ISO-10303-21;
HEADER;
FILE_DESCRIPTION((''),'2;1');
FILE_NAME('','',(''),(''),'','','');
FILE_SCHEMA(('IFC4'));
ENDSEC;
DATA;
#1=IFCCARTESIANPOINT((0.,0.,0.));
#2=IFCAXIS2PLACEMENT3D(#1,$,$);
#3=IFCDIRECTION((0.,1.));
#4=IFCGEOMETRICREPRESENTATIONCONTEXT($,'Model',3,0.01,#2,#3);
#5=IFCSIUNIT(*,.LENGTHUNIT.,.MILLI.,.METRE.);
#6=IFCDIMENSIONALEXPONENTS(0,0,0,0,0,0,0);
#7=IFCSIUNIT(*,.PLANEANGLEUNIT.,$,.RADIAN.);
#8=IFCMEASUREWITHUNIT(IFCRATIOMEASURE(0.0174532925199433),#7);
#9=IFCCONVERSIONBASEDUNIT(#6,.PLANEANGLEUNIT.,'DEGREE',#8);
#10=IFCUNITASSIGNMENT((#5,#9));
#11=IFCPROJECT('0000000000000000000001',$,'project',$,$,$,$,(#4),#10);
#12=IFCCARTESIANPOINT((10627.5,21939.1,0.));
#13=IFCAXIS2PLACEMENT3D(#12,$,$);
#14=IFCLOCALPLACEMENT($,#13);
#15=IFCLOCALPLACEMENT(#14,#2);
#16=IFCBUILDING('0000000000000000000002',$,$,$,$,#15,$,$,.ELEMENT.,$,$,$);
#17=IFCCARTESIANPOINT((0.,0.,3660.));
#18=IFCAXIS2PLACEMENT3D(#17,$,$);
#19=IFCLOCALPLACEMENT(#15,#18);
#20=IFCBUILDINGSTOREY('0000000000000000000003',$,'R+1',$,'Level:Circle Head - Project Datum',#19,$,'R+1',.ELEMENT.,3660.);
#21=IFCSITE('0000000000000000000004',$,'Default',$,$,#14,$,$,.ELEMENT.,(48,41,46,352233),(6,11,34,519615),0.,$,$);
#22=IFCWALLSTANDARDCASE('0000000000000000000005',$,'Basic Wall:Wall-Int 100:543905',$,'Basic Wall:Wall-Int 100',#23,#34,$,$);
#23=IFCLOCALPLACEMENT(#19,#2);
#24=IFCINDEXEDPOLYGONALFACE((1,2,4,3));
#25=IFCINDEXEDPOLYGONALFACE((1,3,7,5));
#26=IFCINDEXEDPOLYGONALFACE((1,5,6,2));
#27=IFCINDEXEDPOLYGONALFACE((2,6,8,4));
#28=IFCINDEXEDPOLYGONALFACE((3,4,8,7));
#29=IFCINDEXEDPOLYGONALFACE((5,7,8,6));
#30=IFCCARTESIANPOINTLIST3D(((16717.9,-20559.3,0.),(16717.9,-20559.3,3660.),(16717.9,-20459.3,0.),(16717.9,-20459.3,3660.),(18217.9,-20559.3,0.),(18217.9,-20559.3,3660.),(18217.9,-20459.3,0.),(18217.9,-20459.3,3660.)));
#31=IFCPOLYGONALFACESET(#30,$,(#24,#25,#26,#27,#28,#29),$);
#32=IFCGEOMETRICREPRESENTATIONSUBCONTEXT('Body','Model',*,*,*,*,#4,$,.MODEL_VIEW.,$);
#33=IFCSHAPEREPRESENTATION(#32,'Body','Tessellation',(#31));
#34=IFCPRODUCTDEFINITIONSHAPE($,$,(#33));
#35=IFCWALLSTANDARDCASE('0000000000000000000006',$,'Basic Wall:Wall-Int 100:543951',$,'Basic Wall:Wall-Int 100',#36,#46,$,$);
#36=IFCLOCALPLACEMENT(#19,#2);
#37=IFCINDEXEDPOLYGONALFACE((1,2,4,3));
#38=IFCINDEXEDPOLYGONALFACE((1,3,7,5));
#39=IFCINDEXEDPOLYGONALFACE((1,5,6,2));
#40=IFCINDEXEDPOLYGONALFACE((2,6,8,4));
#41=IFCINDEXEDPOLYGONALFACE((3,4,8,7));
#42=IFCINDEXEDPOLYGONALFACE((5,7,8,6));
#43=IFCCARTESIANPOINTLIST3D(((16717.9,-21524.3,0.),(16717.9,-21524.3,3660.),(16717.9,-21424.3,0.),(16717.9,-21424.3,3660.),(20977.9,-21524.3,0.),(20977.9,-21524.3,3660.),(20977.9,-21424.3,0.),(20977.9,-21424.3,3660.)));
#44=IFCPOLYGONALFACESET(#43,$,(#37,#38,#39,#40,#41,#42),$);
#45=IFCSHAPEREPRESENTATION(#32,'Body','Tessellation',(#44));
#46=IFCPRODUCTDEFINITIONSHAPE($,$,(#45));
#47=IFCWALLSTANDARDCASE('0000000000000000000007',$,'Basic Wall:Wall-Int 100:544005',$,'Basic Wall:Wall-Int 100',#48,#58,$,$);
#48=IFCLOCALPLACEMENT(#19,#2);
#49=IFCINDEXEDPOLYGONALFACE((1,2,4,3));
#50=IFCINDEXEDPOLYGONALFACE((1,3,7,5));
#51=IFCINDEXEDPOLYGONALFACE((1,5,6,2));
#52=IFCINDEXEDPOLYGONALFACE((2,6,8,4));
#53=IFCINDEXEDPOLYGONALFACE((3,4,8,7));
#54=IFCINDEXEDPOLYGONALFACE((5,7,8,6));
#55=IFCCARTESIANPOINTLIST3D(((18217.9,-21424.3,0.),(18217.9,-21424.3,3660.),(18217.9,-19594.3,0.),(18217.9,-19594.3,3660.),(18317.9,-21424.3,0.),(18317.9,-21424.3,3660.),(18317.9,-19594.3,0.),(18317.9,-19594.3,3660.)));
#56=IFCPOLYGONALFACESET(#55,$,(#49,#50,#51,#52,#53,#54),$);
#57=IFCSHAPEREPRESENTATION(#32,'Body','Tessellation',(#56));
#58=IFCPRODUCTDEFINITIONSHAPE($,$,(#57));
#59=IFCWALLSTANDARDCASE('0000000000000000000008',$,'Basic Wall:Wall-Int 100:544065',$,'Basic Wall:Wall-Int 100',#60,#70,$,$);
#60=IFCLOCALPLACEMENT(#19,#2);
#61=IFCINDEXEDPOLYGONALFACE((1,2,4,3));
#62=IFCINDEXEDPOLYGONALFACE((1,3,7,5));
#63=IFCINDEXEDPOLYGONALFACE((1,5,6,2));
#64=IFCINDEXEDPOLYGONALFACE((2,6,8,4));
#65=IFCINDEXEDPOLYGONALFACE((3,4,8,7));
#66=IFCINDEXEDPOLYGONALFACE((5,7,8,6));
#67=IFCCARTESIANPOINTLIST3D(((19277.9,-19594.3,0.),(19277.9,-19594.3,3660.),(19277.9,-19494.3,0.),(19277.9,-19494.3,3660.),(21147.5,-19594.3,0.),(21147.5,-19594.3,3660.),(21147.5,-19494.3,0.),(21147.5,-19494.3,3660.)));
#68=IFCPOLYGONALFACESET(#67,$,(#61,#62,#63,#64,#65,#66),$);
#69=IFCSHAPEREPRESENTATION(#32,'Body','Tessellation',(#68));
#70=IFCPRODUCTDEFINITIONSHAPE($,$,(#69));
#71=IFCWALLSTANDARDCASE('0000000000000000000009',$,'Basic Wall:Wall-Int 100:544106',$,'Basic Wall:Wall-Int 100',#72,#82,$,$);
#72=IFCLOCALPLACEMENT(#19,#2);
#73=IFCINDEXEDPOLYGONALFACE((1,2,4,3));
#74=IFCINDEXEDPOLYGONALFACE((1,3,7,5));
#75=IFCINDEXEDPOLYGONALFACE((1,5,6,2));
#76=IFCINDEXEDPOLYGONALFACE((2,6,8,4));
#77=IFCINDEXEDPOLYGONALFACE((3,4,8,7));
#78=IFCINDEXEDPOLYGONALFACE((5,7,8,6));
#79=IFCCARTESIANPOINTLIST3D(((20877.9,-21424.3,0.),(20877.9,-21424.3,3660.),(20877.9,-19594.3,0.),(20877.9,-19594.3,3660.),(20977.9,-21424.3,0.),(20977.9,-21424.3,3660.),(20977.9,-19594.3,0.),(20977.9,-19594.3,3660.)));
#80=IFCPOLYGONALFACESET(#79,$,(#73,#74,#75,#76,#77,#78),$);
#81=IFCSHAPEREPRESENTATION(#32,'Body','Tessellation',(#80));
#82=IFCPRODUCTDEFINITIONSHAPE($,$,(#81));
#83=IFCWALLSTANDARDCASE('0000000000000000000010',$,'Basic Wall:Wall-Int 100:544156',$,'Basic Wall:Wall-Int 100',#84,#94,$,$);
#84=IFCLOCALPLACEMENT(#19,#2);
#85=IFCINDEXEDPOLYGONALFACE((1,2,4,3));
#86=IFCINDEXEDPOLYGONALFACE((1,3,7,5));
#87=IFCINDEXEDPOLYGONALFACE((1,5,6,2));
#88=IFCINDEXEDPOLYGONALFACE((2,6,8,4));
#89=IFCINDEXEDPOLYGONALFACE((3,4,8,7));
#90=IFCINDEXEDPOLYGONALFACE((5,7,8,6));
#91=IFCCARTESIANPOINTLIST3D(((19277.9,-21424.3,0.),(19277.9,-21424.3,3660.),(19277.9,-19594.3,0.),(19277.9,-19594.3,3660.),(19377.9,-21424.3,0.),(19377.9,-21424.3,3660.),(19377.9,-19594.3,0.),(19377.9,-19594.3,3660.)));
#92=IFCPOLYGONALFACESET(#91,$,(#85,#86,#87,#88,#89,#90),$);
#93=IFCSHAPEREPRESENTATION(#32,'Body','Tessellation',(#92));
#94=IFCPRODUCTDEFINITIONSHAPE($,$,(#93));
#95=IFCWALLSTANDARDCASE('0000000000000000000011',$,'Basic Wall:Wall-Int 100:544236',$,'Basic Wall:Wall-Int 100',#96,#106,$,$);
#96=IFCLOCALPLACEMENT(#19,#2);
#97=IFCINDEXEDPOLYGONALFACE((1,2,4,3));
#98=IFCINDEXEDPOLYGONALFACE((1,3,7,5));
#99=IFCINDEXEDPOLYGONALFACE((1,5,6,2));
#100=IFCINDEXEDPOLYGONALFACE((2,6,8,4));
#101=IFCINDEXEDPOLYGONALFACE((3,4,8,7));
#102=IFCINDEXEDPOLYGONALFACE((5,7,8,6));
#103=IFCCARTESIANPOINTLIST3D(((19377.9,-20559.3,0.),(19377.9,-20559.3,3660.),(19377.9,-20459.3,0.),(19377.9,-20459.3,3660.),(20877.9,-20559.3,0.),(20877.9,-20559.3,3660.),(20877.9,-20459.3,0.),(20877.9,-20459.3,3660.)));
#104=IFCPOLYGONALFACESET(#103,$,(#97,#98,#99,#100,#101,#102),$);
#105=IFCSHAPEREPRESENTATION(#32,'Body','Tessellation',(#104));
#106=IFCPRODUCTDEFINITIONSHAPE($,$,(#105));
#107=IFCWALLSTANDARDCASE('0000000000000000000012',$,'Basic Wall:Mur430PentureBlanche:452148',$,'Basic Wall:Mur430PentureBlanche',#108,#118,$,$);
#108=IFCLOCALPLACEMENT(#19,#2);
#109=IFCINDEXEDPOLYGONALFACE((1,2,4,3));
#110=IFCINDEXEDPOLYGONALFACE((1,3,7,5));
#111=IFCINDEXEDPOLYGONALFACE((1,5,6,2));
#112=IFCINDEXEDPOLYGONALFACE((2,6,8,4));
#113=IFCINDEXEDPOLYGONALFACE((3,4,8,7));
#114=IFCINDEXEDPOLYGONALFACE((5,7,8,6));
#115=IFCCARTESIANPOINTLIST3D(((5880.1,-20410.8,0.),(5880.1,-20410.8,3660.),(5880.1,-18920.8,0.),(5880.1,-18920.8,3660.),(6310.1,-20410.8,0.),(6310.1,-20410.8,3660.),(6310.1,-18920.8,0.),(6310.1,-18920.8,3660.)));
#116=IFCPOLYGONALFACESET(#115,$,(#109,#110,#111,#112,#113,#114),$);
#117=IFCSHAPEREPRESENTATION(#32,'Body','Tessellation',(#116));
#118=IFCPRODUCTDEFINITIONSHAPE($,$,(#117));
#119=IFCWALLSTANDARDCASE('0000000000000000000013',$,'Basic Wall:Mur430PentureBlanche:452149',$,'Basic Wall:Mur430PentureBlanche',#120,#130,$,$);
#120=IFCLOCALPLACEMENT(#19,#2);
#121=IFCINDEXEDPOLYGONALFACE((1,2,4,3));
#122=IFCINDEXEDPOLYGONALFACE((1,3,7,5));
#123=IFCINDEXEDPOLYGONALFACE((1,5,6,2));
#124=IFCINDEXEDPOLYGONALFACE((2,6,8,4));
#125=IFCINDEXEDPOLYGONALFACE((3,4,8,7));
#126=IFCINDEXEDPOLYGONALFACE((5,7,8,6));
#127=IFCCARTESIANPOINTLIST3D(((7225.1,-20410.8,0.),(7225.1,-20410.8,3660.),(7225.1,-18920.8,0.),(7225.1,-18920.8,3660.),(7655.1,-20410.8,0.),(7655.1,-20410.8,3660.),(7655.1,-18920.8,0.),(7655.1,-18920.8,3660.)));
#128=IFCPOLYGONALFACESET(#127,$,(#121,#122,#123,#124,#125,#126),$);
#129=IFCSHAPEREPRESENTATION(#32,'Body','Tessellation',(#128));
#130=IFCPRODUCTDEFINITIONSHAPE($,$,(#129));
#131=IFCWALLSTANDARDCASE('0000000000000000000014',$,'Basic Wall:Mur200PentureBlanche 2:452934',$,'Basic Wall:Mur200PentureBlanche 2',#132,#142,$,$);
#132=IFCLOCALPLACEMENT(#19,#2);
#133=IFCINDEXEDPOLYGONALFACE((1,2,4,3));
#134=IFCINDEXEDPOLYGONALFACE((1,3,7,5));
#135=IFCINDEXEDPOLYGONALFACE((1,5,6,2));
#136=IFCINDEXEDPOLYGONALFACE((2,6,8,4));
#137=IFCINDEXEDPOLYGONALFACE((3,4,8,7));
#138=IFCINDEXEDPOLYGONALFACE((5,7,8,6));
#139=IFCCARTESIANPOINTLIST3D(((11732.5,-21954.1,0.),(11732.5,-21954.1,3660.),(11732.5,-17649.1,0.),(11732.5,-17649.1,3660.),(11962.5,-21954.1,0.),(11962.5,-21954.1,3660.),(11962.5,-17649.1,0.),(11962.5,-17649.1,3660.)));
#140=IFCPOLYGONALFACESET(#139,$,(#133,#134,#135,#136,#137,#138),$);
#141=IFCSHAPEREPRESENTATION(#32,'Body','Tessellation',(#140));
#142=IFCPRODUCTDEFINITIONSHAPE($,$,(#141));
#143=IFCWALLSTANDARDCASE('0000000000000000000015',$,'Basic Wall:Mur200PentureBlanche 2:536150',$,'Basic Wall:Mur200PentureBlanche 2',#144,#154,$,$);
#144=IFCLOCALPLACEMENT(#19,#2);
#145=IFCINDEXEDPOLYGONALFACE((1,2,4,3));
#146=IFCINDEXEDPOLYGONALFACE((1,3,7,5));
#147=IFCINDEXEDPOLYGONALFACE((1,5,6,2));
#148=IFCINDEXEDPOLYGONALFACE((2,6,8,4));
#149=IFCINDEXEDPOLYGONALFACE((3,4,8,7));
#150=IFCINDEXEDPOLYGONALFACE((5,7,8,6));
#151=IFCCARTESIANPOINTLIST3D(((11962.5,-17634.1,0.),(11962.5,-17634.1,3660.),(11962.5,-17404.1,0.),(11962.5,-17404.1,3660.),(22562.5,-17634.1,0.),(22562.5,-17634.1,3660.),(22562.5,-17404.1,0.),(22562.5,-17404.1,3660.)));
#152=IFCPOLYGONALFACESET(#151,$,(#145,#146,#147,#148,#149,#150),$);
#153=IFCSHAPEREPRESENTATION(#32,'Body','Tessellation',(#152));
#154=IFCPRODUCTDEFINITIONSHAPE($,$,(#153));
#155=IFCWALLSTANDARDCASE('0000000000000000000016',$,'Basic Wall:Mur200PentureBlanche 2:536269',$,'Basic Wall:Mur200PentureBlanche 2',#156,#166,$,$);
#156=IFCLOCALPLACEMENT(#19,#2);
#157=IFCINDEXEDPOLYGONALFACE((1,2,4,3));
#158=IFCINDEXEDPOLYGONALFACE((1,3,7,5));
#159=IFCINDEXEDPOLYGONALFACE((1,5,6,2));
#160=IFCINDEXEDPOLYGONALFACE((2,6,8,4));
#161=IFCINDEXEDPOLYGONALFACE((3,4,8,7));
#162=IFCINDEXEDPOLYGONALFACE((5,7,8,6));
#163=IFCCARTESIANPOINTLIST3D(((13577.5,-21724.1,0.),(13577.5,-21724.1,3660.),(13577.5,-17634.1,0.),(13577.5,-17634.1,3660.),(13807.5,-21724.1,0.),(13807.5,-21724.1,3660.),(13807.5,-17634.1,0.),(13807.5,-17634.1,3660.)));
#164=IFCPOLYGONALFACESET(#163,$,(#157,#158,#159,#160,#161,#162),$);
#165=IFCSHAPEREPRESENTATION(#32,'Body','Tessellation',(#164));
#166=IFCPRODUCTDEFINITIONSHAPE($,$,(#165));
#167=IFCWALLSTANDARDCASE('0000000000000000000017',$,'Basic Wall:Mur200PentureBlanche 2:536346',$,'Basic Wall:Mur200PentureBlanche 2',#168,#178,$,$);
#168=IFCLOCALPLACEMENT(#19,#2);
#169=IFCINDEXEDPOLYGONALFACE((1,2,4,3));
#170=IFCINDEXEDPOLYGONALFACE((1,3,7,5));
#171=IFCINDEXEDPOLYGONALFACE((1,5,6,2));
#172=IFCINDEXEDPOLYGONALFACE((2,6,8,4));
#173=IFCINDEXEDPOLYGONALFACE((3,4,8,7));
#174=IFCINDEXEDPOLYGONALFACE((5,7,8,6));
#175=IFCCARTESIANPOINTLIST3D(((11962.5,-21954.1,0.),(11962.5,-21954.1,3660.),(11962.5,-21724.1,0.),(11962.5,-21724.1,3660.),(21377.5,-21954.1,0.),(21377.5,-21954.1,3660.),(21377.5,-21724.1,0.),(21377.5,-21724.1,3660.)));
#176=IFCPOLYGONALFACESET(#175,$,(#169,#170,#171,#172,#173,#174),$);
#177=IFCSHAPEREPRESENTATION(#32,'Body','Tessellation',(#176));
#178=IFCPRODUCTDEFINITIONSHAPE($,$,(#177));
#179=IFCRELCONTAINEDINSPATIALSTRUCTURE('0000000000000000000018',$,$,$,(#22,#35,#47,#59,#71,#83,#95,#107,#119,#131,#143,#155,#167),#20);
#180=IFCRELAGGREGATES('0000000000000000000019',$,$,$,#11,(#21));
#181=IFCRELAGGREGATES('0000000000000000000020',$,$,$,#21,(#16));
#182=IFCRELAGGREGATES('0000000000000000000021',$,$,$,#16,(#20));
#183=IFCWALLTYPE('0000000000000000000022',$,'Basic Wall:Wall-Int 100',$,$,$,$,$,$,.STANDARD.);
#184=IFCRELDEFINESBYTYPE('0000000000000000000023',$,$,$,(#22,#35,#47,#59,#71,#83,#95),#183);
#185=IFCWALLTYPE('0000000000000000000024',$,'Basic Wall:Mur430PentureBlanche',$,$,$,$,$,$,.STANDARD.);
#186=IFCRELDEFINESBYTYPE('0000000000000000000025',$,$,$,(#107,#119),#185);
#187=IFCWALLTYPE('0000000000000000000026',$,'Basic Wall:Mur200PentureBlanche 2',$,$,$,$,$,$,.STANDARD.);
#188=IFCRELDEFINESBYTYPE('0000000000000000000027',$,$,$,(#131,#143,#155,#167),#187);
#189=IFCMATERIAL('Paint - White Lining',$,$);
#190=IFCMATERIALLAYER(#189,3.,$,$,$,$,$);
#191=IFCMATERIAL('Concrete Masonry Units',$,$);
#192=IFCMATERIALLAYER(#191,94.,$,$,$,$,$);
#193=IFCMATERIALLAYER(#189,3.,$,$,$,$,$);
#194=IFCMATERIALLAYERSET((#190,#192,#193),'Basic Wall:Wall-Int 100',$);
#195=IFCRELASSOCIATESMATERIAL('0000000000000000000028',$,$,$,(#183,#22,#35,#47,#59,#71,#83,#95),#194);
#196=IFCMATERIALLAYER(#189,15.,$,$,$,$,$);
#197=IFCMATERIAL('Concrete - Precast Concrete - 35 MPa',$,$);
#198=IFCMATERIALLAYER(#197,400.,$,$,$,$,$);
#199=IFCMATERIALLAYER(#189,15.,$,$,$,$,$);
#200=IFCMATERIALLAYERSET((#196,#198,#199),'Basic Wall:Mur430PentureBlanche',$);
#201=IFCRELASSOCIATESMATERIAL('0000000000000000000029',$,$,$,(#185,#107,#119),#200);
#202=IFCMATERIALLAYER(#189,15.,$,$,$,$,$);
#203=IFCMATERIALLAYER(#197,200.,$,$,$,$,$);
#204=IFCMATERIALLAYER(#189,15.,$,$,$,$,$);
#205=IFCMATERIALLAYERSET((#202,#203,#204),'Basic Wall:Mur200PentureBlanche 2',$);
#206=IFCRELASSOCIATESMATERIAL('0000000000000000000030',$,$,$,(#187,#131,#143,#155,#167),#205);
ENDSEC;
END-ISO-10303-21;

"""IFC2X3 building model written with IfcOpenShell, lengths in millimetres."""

from ifc_helpers import new_model, entity, si_unit, converted_unit, direction, frame, frame_2d, origin, place, context, subcontext, project, spatial, rectangle, extrude, material, layer, layer_set, layer_usage, type_object, element, save


model = new_model("IFC2X3")

# Units and contexts
model_context = context("Model", 3, precision=0.01, world=origin(), true_north=direction((0.0, 1.0)))
body_context = subcontext(model_context, "Body", "Model", "MODEL_VIEW")
ifc_project = project(units=[si_unit("LENGTHUNIT", "METRE", prefix="MILLI"), converted_unit("PLANEANGLEUNIT", "DEGREE", entity("IfcRatioMeasure", 0.0174532925199433), si_unit("PLANEANGLEUNIT", "RADIAN"), dimensions=[0, 0, 0, 0, 0, 0, 0])], contexts=[model_context])

# Site, building, storey
site_placement = place(None, frame((10627.5, 21939.1, 0.0)))
site = spatial("IfcSite", under=ifc_project, at=site_placement, Name="Default", CompositionType="ELEMENT", RefLatitude=(48, 41, 46, 352233), RefLongitude=(6, 11, 34, 519615), RefElevation=0.0)
building_placement = place(site_placement, origin())
building = spatial("IfcBuilding", under=site, at=building_placement, CompositionType="ELEMENT")
storey_placement = place(building_placement, frame((0.0, 0.0, 3660.0)))
storey = spatial("IfcBuildingStorey", under=building, at=storey_placement, Name="R+1", ObjectType="Level:Circle Head - Project Datum", LongName="R+1", CompositionType="ELEMENT", Elevation=3660.0)

# Walls
ifc_material_1 = material(Name="Paint - White Lining")
ifc_layer_1 = layer(ifc_material_1, 3.0)
ifc_material_2 = material(Name="Concrete Masonry Units")
ifc_layer_2 = layer(ifc_material_2, 94.0)
ifc_layer_3 = layer(ifc_material_1, 3.0)
ifc_layer_set_1 = layer_set([ifc_layer_1, ifc_layer_2, ifc_layer_3], Name="Basic Wall:Wall-Int 100")
wall_type_1 = type_object("IfcWallType", Name="Basic Wall:Wall-Int 100", PredefinedType="STANDARD", material=ifc_layer_set_1)
ifc_layer_usage_1 = layer_usage(ifc_layer_set_1, "AXIS2", "POSITIVE", -50.0)
wall_1_placement = place(storey_placement, frame((18217.9, -20509.3, 0.0), z_axis=(0.0, 0.0, 1.0), x_axis=(-1.0, 0.0, 0.0)))
element("IfcWallStandardCase", 1, at=wall_1_placement, inside=storey, type_object=wall_type_1, material=ifc_layer_usage_1, Name="Basic Wall:Wall-Int 100:543905", ObjectType="Basic Wall:Wall-Int 100", context=body_context, shape_type="SweptSolid", body=[
    extrude(rectangle(XDim=1500.0, YDim=100.0, at=frame_2d((750.0, 0.0), x_axis=(-1.0, 0.0))), origin(), (0.0, 0.0, 1.0), 3660.0),
])
ifc_layer_usage_2 = layer_usage(ifc_layer_set_1, "AXIS2", "NEGATIVE", 50.0)
wall_2_placement = place(storey_placement, frame((20977.9, -21474.3, 0.0), z_axis=(0.0, 0.0, 1.0), x_axis=(-1.0, 0.0, 0.0)))
element("IfcWallStandardCase", 2, at=wall_2_placement, inside=storey, type_object=wall_type_1, material=ifc_layer_usage_2, Name="Basic Wall:Wall-Int 100:543951", ObjectType="Basic Wall:Wall-Int 100", context=body_context, shape_type="SweptSolid", body=[
    extrude(rectangle(XDim=4260.0, YDim=100.0, at=frame_2d((2130.0, 0.0), x_axis=(-1.0, 0.0))), origin(), (0.0, 0.0, 1.0), 3660.0),
])
ifc_layer_usage_3 = layer_usage(ifc_layer_set_1, "AXIS2", "POSITIVE", -50.0)
wall_3_placement = place(storey_placement, frame((18267.9, -21424.3, 0.0), z_axis=(0.0, 0.0, 1.0), x_axis=(0.0, 1.0, 0.0)))
element("IfcWallStandardCase", 3, at=wall_3_placement, inside=storey, type_object=wall_type_1, material=ifc_layer_usage_3, Name="Basic Wall:Wall-Int 100:544005", ObjectType="Basic Wall:Wall-Int 100", context=body_context, shape_type="SweptSolid", body=[
    extrude(rectangle(XDim=1830.0, YDim=100.0, at=frame_2d((915.0, 0.0), x_axis=(-1.0, 0.0))), origin(), (0.0, 0.0, 1.0), 3660.0),
])
ifc_layer_usage_4 = layer_usage(ifc_layer_set_1, "AXIS2", "NEGATIVE", 50.0)
wall_4_placement = place(storey_placement, frame((19277.9, -19544.3, 0.0)))
element("IfcWallStandardCase", 4, at=wall_4_placement, inside=storey, type_object=wall_type_1, material=ifc_layer_usage_4, Name="Basic Wall:Wall-Int 100:544065", ObjectType="Basic Wall:Wall-Int 100", context=body_context, shape_type="SweptSolid", body=[
    extrude(rectangle(XDim=1869.6, YDim=100.0, at=frame_2d((934.8, 0.0), x_axis=(-1.0, 0.0))), origin(), (0.0, 0.0, 1.0), 3660.0),
])
ifc_layer_usage_5 = layer_usage(ifc_layer_set_1, "AXIS2", "NEGATIVE", 50.0)
wall_5_placement = place(storey_placement, frame((20927.9, -19594.3, 0.0), z_axis=(0.0, 0.0, 1.0), x_axis=(0.0, -1.0, 0.0)))
element("IfcWallStandardCase", 5, at=wall_5_placement, inside=storey, type_object=wall_type_1, material=ifc_layer_usage_5, Name="Basic Wall:Wall-Int 100:544106", ObjectType="Basic Wall:Wall-Int 100", context=body_context, shape_type="SweptSolid", body=[
    extrude(rectangle(XDim=1830.0, YDim=100.0, at=frame_2d((915.0, 0.0), x_axis=(-1.0, 0.0))), origin(), (0.0, 0.0, 1.0), 3660.0),
])
ifc_layer_usage_6 = layer_usage(ifc_layer_set_1, "AXIS2", "POSITIVE", -50.0)
wall_6_placement = place(storey_placement, frame((19327.9, -19594.3, 0.0), z_axis=(0.0, 0.0, 1.0), x_axis=(0.0, -1.0, 0.0)))
element("IfcWallStandardCase", 6, at=wall_6_placement, inside=storey, type_object=wall_type_1, material=ifc_layer_usage_6, Name="Basic Wall:Wall-Int 100:544156", ObjectType="Basic Wall:Wall-Int 100", context=body_context, shape_type="SweptSolid", body=[
    extrude(rectangle(XDim=1830.0, YDim=100.0, at=frame_2d((915.0, 0.0), x_axis=(-1.0, 0.0))), origin(), (0.0, 0.0, 1.0), 3660.0),
])
ifc_layer_usage_7 = layer_usage(ifc_layer_set_1, "AXIS2", "NEGATIVE", 50.0)
wall_7_placement = place(storey_placement, frame((19377.9, -20509.3, 0.0)))
element("IfcWallStandardCase", 7, at=wall_7_placement, inside=storey, type_object=wall_type_1, material=ifc_layer_usage_7, Name="Basic Wall:Wall-Int 100:544236", ObjectType="Basic Wall:Wall-Int 100", context=body_context, shape_type="SweptSolid", body=[
    extrude(rectangle(XDim=1500.0, YDim=100.0, at=frame_2d((750.0, 0.0), x_axis=(-1.0, 0.0))), origin(), (0.0, 0.0, 1.0), 3660.0),
])
ifc_layer_4 = layer(ifc_material_1, 15.0)
ifc_material_3 = material(Name="Concrete - Precast Concrete - 35 MPa")
ifc_layer_5 = layer(ifc_material_3, 400.0)
ifc_layer_6 = layer(ifc_material_1, 15.0)
ifc_layer_set_2 = layer_set([ifc_layer_4, ifc_layer_5, ifc_layer_6], Name="Basic Wall:Mur430PentureBlanche")
ifc_layer_usage_8 = layer_usage(ifc_layer_set_2, "AXIS2", "NEGATIVE", 215.0)
wall_type_2 = type_object("IfcWallType", Name="Basic Wall:Mur430PentureBlanche", PredefinedType="STANDARD", material=ifc_layer_set_2)
wall_8_placement = place(storey_placement, frame((6095.1, -18920.8, 0.0), z_axis=(0.0, 0.0, 1.0), x_axis=(0.0, -1.0, 0.0)))
element("IfcWallStandardCase", 8, at=wall_8_placement, inside=storey, type_object=wall_type_2, material=ifc_layer_usage_8, Name="Basic Wall:Mur430PentureBlanche:452148", ObjectType="Basic Wall:Mur430PentureBlanche", context=body_context, shape_type="SweptSolid", body=[
    extrude(rectangle(XDim=1490.0, YDim=430.0, at=frame_2d((745.0, 0.0), x_axis=(-1.0, 0.0))), origin(), (0.0, 0.0, 1.0), 3660.0),
])
ifc_layer_usage_9 = layer_usage(ifc_layer_set_2, "AXIS2", "NEGATIVE", 215.0)
wall_9_placement = place(storey_placement, frame((7440.1, -18920.8, 0.0), z_axis=(0.0, 0.0, 1.0), x_axis=(0.0, -1.0, 0.0)))
element("IfcWallStandardCase", 9, at=wall_9_placement, inside=storey, type_object=wall_type_2, material=ifc_layer_usage_9, Name="Basic Wall:Mur430PentureBlanche:452149", ObjectType="Basic Wall:Mur430PentureBlanche", context=body_context, shape_type="SweptSolid", body=[
    extrude(rectangle(XDim=1490.0, YDim=430.0, at=frame_2d((745.0, 0.0), x_axis=(-1.0, 0.0))), origin(), (0.0, 0.0, 1.0), 3660.0),
])
ifc_layer_7 = layer(ifc_material_1, 15.0)
ifc_layer_8 = layer(ifc_material_3, 200.0)
ifc_layer_9 = layer(ifc_material_1, 15.0)
ifc_layer_set_3 = layer_set([ifc_layer_7, ifc_layer_8, ifc_layer_9], Name="Basic Wall:Mur200PentureBlanche 2")
ifc_layer_usage_10 = layer_usage(ifc_layer_set_3, "AXIS2", "POSITIVE", -115.0)
wall_type_3 = type_object("IfcWallType", Name="Basic Wall:Mur200PentureBlanche 2", PredefinedType="STANDARD", material=ifc_layer_set_3)
wall_10_placement = place(storey_placement, frame((11847.5, -17649.1, 0.0), z_axis=(0.0, 0.0, 1.0), x_axis=(0.0, -1.0, 0.0)))
element("IfcWallStandardCase", 10, at=wall_10_placement, inside=storey, type_object=wall_type_3, material=ifc_layer_usage_10, Name="Basic Wall:Mur200PentureBlanche 2:452934", ObjectType="Basic Wall:Mur200PentureBlanche 2", context=body_context, shape_type="SweptSolid", body=[
    extrude(rectangle(XDim=4305.0, YDim=230.0, at=frame_2d((2152.5, 0.0), x_axis=(-1.0, 0.0))), origin(), (0.0, 0.0, 1.0), 3660.0),
])
ifc_layer_usage_11 = layer_usage(ifc_layer_set_3, "AXIS2", "NEGATIVE", 115.0)
wall_11_placement = place(storey_placement, frame((11962.5, -17519.1, 0.0)))
element("IfcWallStandardCase", 11, at=wall_11_placement, inside=storey, type_object=wall_type_3, material=ifc_layer_usage_11, Name="Basic Wall:Mur200PentureBlanche 2:536150", ObjectType="Basic Wall:Mur200PentureBlanche 2", context=body_context, shape_type="SweptSolid", body=[
    extrude(rectangle(XDim=10600.0, YDim=230.0, at=frame_2d((5300.0, 0.0), x_axis=(-1.0, 0.0))), origin(), (0.0, 0.0, 1.0), 3660.0),
])
ifc_layer_usage_12 = layer_usage(ifc_layer_set_3, "AXIS2", "NEGATIVE", 115.0)
wall_12_placement = place(storey_placement, frame((13692.5, -17634.1, 0.0), z_axis=(0.0, 0.0, 1.0), x_axis=(0.0, -1.0, 0.0)))
element("IfcWallStandardCase", 12, at=wall_12_placement, inside=storey, type_object=wall_type_3, material=ifc_layer_usage_12, Name="Basic Wall:Mur200PentureBlanche 2:536269", ObjectType="Basic Wall:Mur200PentureBlanche 2", context=body_context, shape_type="SweptSolid", body=[
    extrude(rectangle(XDim=4090.0, YDim=230.0, at=frame_2d((2045.0, 0.0), x_axis=(-1.0, 0.0))), origin(), (0.0, 0.0, 1.0), 3660.0),
])
ifc_layer_usage_13 = layer_usage(ifc_layer_set_3, "AXIS2", "POSITIVE", -115.0)
wall_13_placement = place(storey_placement, frame((11962.5, -21839.1, 0.0)))
element("IfcWallStandardCase", 13, at=wall_13_placement, inside=storey, type_object=wall_type_3, material=ifc_layer_usage_13, Name="Basic Wall:Mur200PentureBlanche 2:536346", ObjectType="Basic Wall:Mur200PentureBlanche 2", context=body_context, shape_type="SweptSolid", body=[
    extrude(rectangle(XDim=9415.0, YDim=230.0, at=frame_2d((4707.5, 0.0), x_axis=(-1.0, 0.0))), origin(), (0.0, 0.0, 1.0), 3660.0),
])

save(model, "model.ifc")
